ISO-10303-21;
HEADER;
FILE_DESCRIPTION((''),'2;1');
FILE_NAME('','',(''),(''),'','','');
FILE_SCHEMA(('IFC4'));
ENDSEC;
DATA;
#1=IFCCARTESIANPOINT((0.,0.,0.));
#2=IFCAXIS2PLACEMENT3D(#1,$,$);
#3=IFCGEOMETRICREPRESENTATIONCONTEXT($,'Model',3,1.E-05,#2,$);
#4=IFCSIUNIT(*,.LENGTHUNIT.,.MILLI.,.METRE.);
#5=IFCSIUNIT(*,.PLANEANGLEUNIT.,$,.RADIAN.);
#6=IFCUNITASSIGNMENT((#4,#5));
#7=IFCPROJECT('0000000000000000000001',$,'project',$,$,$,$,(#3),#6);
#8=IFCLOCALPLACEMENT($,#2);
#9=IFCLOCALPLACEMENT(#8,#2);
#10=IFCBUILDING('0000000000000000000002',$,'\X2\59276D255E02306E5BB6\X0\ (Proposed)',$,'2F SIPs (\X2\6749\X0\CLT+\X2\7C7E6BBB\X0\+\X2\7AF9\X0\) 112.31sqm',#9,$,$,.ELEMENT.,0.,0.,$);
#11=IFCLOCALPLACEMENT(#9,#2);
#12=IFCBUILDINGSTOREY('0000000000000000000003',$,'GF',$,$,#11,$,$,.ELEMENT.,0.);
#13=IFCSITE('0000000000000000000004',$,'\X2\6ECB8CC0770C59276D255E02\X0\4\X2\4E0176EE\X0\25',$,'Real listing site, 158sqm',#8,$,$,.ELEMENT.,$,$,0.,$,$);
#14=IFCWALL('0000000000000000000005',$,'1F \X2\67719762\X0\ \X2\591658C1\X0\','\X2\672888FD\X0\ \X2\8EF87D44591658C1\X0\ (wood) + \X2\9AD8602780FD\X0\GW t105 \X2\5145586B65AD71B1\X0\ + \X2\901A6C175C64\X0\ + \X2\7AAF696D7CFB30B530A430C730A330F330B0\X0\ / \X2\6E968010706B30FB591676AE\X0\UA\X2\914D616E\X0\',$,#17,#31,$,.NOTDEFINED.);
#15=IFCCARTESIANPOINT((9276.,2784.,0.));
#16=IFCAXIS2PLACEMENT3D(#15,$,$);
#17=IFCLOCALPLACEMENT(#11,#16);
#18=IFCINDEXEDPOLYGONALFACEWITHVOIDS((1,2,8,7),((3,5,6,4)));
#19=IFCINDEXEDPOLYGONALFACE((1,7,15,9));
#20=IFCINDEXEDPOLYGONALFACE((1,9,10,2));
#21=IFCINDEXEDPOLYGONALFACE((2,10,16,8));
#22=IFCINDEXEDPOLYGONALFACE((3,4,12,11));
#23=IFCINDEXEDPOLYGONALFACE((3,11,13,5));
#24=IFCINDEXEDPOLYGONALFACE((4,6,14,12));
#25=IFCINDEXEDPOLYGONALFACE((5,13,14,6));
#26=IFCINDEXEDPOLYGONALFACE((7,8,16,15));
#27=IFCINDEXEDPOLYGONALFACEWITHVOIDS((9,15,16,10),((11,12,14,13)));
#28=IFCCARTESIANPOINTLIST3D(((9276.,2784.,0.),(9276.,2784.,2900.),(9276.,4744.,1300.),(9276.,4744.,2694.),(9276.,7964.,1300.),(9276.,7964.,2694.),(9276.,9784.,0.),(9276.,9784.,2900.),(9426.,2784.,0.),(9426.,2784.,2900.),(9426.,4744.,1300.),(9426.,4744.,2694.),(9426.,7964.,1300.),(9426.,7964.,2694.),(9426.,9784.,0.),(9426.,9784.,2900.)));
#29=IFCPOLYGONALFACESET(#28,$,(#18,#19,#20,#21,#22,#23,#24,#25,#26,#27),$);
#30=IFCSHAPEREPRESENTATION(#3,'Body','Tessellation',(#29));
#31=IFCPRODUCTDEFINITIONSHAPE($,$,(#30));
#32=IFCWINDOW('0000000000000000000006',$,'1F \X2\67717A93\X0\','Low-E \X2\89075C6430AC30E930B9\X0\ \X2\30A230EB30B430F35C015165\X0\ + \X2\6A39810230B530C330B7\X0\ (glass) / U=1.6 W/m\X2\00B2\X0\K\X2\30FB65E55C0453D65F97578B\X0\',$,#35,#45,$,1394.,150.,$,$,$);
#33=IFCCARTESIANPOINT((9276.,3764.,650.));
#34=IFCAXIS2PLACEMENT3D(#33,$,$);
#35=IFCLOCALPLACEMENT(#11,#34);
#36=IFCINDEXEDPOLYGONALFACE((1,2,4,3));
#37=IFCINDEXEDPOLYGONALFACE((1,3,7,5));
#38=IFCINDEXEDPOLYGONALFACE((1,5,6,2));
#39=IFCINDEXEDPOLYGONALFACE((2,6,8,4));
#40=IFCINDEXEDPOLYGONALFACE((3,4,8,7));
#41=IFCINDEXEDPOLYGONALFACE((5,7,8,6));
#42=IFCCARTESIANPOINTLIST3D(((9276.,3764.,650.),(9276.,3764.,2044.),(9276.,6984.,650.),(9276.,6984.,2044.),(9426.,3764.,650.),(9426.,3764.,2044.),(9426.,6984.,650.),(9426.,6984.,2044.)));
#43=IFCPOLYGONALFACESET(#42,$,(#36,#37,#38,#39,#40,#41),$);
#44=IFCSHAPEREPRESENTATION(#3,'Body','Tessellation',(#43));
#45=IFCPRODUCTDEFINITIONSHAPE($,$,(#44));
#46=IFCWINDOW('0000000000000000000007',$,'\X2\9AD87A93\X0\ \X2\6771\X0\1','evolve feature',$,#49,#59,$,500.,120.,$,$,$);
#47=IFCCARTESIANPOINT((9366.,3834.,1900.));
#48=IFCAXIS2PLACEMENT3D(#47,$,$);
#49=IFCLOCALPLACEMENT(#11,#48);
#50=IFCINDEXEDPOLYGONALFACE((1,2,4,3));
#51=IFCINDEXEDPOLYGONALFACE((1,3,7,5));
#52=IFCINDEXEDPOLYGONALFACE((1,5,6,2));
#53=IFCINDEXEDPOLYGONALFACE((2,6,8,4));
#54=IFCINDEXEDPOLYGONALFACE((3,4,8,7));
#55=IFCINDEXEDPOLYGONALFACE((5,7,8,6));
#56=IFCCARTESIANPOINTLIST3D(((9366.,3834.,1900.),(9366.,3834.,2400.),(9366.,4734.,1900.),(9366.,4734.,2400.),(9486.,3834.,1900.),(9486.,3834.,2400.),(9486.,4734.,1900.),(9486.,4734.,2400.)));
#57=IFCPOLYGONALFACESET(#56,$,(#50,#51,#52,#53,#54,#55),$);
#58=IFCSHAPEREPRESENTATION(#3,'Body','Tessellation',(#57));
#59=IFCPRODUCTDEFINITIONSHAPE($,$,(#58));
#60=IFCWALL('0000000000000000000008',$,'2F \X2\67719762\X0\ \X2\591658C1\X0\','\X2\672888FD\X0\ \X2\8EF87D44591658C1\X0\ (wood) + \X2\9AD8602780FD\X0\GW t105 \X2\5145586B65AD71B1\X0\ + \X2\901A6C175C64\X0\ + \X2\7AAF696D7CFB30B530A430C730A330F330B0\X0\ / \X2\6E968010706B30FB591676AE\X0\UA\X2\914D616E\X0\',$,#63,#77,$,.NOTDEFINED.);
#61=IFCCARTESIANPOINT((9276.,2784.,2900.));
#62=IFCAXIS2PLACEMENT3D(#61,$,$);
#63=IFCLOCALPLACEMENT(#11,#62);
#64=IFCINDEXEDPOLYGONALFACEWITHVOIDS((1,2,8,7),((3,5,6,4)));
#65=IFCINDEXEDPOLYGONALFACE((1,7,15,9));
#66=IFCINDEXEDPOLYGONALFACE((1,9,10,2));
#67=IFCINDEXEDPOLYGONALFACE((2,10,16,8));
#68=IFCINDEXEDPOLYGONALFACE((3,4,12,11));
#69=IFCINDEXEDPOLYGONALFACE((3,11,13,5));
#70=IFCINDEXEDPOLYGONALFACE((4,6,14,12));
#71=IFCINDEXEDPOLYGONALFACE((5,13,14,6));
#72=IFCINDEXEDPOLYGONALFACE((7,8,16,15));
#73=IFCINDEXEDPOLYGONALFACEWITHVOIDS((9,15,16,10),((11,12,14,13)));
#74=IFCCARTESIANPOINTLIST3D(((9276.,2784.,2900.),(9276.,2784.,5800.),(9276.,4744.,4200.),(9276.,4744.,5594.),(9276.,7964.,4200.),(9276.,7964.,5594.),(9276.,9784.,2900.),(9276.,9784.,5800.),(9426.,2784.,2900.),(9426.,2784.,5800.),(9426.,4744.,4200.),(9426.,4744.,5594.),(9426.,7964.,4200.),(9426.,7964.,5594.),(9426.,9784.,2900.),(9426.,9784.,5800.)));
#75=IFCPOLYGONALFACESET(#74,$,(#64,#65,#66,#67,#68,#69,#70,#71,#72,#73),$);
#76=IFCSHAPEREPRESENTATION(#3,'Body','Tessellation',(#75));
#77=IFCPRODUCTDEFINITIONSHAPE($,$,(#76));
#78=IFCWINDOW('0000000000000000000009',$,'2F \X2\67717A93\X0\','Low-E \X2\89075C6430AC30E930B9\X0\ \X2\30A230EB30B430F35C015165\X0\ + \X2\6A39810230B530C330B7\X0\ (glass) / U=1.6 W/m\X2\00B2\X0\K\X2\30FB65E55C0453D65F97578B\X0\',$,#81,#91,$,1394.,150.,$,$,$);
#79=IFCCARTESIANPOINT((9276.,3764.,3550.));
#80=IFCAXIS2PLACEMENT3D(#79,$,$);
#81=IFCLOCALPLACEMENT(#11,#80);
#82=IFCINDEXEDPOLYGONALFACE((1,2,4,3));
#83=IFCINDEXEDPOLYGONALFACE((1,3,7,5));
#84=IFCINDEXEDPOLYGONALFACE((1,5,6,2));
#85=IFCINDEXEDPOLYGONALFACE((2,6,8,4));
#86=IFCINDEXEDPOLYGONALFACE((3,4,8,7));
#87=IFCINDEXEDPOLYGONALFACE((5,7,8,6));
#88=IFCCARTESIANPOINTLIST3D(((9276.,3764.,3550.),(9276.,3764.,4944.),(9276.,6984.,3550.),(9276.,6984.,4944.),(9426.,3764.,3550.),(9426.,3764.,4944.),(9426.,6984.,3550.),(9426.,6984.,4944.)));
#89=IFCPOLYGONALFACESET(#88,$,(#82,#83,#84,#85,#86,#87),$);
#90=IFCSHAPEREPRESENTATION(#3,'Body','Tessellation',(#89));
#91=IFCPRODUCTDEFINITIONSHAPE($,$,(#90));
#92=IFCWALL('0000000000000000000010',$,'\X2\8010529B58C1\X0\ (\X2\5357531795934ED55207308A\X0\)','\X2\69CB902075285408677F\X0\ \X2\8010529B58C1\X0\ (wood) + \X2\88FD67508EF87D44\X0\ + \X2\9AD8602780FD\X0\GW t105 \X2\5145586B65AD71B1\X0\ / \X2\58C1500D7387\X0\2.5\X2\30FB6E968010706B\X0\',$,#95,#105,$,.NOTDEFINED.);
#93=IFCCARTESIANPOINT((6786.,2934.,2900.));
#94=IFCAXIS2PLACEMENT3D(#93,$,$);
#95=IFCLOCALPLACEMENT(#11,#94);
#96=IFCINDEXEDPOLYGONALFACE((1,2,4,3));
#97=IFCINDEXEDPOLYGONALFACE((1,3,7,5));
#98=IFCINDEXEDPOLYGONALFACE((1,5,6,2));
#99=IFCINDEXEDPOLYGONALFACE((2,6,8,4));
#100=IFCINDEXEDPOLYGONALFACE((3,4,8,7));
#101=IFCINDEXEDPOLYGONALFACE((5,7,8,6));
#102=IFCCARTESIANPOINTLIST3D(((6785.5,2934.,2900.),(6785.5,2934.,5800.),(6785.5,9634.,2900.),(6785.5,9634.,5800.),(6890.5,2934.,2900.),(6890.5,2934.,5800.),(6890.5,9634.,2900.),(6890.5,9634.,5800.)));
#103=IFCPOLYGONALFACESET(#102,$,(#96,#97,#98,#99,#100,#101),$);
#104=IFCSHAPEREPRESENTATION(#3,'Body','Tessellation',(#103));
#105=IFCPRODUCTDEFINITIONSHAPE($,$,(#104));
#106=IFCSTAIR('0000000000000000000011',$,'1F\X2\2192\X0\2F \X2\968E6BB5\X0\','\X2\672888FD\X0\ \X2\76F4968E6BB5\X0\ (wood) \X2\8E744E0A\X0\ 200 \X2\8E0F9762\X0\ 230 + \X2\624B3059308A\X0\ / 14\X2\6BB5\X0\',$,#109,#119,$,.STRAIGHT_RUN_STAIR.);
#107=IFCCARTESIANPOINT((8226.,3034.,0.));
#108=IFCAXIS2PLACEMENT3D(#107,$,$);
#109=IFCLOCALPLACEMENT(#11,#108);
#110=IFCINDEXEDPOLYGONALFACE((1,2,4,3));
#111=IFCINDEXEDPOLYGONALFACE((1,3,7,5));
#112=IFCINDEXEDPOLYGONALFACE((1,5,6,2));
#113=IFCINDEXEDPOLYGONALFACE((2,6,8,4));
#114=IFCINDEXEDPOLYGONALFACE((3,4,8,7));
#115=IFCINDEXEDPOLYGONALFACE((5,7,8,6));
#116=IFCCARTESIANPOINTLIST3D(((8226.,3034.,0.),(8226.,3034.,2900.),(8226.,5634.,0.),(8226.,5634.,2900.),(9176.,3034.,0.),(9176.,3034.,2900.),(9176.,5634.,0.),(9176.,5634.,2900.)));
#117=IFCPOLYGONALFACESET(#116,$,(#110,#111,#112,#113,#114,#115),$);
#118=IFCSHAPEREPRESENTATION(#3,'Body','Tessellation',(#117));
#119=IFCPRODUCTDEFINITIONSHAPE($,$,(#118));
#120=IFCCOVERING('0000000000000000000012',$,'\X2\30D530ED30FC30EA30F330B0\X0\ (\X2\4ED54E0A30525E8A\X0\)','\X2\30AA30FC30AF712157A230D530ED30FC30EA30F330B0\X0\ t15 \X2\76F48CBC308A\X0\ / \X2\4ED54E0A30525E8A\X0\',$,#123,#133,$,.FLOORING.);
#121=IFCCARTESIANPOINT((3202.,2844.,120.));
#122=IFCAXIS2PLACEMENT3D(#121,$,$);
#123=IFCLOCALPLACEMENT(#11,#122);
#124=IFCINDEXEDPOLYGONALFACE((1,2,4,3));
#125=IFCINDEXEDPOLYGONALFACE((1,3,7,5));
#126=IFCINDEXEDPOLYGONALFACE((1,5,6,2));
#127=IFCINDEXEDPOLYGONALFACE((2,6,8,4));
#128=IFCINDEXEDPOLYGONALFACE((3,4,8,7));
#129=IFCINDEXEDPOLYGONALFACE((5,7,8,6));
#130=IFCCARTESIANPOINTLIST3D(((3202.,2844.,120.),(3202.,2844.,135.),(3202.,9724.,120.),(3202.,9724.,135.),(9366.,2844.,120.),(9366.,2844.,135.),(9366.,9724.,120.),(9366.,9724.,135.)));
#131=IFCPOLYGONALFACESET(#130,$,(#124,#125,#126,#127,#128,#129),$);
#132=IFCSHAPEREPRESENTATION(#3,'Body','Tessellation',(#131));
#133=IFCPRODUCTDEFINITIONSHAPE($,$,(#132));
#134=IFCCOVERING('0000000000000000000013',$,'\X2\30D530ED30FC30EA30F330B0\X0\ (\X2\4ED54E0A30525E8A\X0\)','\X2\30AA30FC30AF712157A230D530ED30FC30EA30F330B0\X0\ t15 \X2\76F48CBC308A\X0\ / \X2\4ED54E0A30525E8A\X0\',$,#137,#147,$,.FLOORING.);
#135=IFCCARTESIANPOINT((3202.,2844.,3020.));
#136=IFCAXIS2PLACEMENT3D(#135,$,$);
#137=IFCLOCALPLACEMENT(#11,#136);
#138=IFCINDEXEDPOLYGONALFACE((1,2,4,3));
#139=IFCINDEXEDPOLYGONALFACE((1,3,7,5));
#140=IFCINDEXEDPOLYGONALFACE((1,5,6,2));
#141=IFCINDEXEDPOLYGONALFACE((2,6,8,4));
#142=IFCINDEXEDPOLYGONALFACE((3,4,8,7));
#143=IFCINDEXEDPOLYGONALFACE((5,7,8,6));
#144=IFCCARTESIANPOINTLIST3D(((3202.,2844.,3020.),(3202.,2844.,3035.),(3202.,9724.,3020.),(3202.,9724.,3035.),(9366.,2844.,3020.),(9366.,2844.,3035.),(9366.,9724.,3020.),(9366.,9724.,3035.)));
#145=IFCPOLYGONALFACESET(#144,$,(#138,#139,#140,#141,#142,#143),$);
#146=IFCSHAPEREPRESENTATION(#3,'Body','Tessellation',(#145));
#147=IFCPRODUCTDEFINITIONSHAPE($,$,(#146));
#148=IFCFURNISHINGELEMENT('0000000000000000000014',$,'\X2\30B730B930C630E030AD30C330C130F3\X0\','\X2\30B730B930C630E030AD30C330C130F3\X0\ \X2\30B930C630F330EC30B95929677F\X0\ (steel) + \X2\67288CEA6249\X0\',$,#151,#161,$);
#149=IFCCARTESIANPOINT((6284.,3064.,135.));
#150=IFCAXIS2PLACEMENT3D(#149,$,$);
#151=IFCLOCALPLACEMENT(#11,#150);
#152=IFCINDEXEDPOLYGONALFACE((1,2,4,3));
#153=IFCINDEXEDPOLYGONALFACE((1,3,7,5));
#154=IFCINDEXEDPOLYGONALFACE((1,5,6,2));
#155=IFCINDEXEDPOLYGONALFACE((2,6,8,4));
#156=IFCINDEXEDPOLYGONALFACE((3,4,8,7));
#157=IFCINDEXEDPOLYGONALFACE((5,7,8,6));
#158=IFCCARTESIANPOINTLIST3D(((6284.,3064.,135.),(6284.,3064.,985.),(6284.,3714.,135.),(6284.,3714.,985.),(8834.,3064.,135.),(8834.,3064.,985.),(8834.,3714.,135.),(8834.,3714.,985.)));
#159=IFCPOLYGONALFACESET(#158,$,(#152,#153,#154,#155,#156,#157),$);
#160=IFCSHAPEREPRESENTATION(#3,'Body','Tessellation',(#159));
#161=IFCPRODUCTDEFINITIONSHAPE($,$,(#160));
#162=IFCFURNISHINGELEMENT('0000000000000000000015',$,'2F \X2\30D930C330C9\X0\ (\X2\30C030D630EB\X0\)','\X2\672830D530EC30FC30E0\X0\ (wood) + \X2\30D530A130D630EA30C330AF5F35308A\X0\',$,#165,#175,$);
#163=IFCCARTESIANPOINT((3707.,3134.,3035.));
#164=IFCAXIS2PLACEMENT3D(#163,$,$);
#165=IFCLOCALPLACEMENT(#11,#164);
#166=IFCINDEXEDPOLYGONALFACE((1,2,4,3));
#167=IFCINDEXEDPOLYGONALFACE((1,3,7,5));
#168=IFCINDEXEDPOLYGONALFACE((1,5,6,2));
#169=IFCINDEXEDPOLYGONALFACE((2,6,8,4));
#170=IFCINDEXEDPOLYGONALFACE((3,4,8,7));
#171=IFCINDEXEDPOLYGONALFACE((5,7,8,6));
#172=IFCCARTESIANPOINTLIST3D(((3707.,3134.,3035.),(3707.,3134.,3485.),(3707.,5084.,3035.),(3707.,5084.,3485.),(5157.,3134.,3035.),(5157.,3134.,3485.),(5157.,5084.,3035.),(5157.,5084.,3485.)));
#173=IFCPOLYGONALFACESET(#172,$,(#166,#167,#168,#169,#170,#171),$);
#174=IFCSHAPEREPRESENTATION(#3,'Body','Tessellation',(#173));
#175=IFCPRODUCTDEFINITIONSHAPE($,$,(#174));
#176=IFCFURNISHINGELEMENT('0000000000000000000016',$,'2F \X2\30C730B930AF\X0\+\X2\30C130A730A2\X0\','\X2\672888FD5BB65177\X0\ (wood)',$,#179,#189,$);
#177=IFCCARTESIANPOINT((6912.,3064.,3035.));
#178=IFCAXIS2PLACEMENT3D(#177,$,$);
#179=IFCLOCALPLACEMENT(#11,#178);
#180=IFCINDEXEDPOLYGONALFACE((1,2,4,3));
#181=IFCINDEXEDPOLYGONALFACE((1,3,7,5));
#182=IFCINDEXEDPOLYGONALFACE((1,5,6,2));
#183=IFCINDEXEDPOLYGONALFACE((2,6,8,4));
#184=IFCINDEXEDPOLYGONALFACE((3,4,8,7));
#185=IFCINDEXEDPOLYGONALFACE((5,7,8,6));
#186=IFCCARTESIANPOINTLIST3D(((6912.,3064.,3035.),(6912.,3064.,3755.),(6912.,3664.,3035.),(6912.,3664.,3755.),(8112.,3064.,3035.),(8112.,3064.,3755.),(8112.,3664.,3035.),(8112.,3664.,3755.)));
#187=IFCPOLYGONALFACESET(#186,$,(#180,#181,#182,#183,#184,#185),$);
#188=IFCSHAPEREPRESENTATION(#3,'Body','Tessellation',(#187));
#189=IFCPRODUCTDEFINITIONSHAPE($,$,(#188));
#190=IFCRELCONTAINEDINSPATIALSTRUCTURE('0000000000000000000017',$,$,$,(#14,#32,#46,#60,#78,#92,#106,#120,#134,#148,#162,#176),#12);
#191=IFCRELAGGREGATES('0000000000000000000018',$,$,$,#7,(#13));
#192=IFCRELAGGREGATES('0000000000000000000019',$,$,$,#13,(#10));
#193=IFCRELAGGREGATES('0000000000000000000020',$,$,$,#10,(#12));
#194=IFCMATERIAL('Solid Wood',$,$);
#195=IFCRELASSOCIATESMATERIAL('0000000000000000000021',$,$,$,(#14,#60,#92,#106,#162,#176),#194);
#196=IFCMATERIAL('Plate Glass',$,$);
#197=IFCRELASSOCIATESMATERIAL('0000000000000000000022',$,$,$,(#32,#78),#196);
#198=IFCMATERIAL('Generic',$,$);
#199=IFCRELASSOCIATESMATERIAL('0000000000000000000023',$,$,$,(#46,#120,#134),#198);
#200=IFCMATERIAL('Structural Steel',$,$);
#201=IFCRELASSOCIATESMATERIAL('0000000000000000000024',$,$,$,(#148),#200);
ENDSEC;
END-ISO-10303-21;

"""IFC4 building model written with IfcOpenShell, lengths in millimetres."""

from ifc_helpers import new_model, si_unit, frame, frame_2d, origin, place, context, project, spatial, rectangle, extrude, material, element, fill, save


model = new_model("IFC4")

# Units and contexts
model_context = context("Model", 3, precision=1e-05, world=origin())
ifc_project = project(units=[si_unit("LENGTHUNIT", "METRE", prefix="MILLI"), si_unit("PLANEANGLEUNIT", "RADIAN")], contexts=[model_context])

# Site, building, storey
site_placement = place(None, origin())
site = spatial("IfcSite", under=ifc_project, at=site_placement, Name="滋賀県大津市4丁目25", ObjectType="Real listing site, 158sqm", CompositionType="ELEMENT", RefElevation=0.0)
building_placement = place(site_placement, origin())
building = spatial("IfcBuilding", under=site, at=building_placement, Name="大津市の家 (Proposed)", ObjectType="2F SIPs (杉CLT+籾殻+竹) 112.31sqm", CompositionType="ELEMENT", ElevationOfRefHeight=0.0, ElevationOfTerrain=0.0)
storey_placement = place(building_placement, origin())
storey = spatial("IfcBuildingStorey", under=building, at=storey_placement, Name="GF", CompositionType="ELEMENT", Elevation=0.0)

# Shared definitions
ifc_material_1 = material(Name="Solid Wood")

# Wall, openings, windows
wall_1_placement = place(storey_placement, frame((9276.0, 2784.0, 0.0)))
wall_1 = element("IfcWall", 1, at=wall_1_placement, inside=storey, material=ifc_material_1, Name="1F 東面 外壁", Description="木製 軸組外壁 (wood) + 高性能GW t105 充填断熱 + 通気層 + 窯業系サイディング / 準耐火・外皮UA配慮", PredefinedType="NOTDEFINED", context=model_context, shape_type="SweptSolid", body=[
    extrude(rectangle(XDim=150.0, YDim=7000.0, at=frame_2d((75.0, 3500.0))), frame((9276.0, 2784.0, 0.0)), (0.0, 0.0, 1.0), 2900.0),
])
opening_1_placement = place(storey_placement, frame((9276.0, 3764.0, 650.0)))
opening_1 = element("IfcOpeningElement", 2, at=opening_1_placement, cuts=wall_1, PredefinedType="NOTDEFINED", context=model_context, shape_type="SweptSolid", body=[
    extrude(rectangle(XDim=150.0, YDim=3220.0, at=frame_2d((75.0, 1610.0))), frame((9276.0, 3764.0, 650.0)), (0.0, 0.0, 1.0), 1394.0),
])
opening_2_placement = place(storey_placement, frame((9366.0, 3834.0, 1900.0)))
opening_2 = element("IfcOpeningElement", 3, at=opening_2_placement, cuts=wall_1, PredefinedType="NOTDEFINED", context=model_context, shape_type="SweptSolid", body=[
    extrude(rectangle(XDim=120.0, YDim=900.0, at=frame_2d((60.0, 450.0))), frame((9366.0, 3834.0, 1900.0)), (0.0, 0.0, 1.0), 500.0),
])
ifc_material_2 = material(Name="Plate Glass")
window_1_placement = place(storey_placement, frame((9276.0, 3764.0, 650.0)))
window_1 = element("IfcWindow", 4, at=window_1_placement, inside=storey, material=ifc_material_2, Name="1F 東窓", Description="Low-E 複層ガラス アルゴン封入 + 樹脂サッシ (glass) / U=1.6 W/m²K・日射取得型", OverallHeight=1394.0, OverallWidth=150.0, context=model_context, shape_type="SweptSolid", body=[
    extrude(rectangle(XDim=150.0, YDim=3220.0, at=frame_2d((75.0, 1610.0))), frame((9276.0, 3764.0, 650.0)), (0.0, 0.0, 1.0), 1394.0),
])
fill(opening_1, window_1)
ifc_material_3 = material(Name="Generic")
window_2_placement = place(storey_placement, frame((9366.0, 3834.0, 1900.0)))
window_2 = element("IfcWindow", 5, at=window_2_placement, inside=storey, material=ifc_material_3, Name="高窓 東1", Description="evolve feature", OverallHeight=500.0, OverallWidth=120.0, context=model_context, shape_type="SweptSolid", body=[
    extrude(rectangle(XDim=120.0, YDim=900.0, at=frame_2d((60.0, 450.0))), frame((9366.0, 3834.0, 1900.0)), (0.0, 0.0, 1.0), 500.0),
])
fill(opening_2, window_2)

# Wall, opening, window
wall_2_placement = place(storey_placement, frame((9276.0, 2784.0, 2900.0)))
wall_2 = element("IfcWall", 6, at=wall_2_placement, inside=storey, material=ifc_material_1, Name="2F 東面 外壁", Description="木製 軸組外壁 (wood) + 高性能GW t105 充填断熱 + 通気層 + 窯業系サイディング / 準耐火・外皮UA配慮", PredefinedType="NOTDEFINED", context=model_context, shape_type="SweptSolid", body=[
    extrude(rectangle(XDim=150.0, YDim=7000.0, at=frame_2d((75.0, 3500.0))), frame((9276.0, 2784.0, 2900.0)), (0.0, 0.0, 1.0), 2900.0),
])
opening_3_placement = place(storey_placement, frame((9276.0, 3764.0, 3550.0)))
opening_3 = element("IfcOpeningElement", 7, at=opening_3_placement, cuts=wall_2, PredefinedType="NOTDEFINED", context=model_context, shape_type="SweptSolid", body=[
    extrude(rectangle(XDim=150.0, YDim=3220.0, at=frame_2d((75.0, 1610.0))), frame((9276.0, 3764.0, 3550.0)), (0.0, 0.0, 1.0), 1394.0),
])
window_3_placement = place(storey_placement, frame((9276.0, 3764.0, 3550.0)))
window_3 = element("IfcWindow", 8, at=window_3_placement, inside=storey, material=ifc_material_2, Name="2F 東窓", Description="Low-E 複層ガラス アルゴン封入 + 樹脂サッシ (glass) / U=1.6 W/m²K・日射取得型", OverallHeight=1394.0, OverallWidth=150.0, context=model_context, shape_type="SweptSolid", body=[
    extrude(rectangle(XDim=150.0, YDim=3220.0, at=frame_2d((75.0, 1610.0))), frame((9276.0, 3764.0, 3550.0)), (0.0, 0.0, 1.0), 1394.0),
])
fill(opening_3, window_3)

# Wall
wall_3_placement = place(storey_placement, frame((6786.0, 2934.0, 2900.0)))
element("IfcWall", 9, at=wall_3_placement, inside=storey, material=ifc_material_1, Name="耐力壁 (南北間仕切り)", Description="構造用合板 耐力壁 (wood) + 製材軸組 + 高性能GW t105 充填断熱 / 壁倍率2.5・準耐火", PredefinedType="NOTDEFINED", context=model_context, shape_type="SweptSolid", body=[
    extrude(rectangle(XDim=105.0, YDim=6700.0, at=frame_2d((52.0, 3350.0))), frame((6786.0, 2934.0, 2900.0)), (0.0, 0.0, 1.0), 2900.0),
])

# Stair
stair_placement = place(storey_placement, frame((8226.0, 3034.0, 0.0)))
element("IfcStair", 10, at=stair_placement, inside=storey, material=ifc_material_1, Name="1F→2F 階段", Description="木製 直階段 (wood) 蹴上 200 踏面 230 + 手すり / 14段", PredefinedType="STRAIGHT_RUN_STAIR", context=model_context, shape_type="SweptSolid", body=[
    extrude(rectangle(XDim=950.0, YDim=2600.0, at=frame_2d((475.0, 1300.0))), frame((8226.0, 3034.0, 0.0)), (0.0, 0.0, 1.0), 2900.0),
])

# Coverings
covering_1_placement = place(storey_placement, frame((3202.0, 2844.0, 120.0)))
element("IfcCovering", 11, at=covering_1_placement, inside=storey, material=ifc_material_3, Name="フローリング (仕上げ床)", Description="オーク無垢フローリング t15 直貼り / 仕上げ床", PredefinedType="FLOORING", context=model_context, shape_type="SweptSolid", body=[
    extrude(rectangle(XDim=6164.0, YDim=6880.0, at=frame_2d((3082.0, 3440.0))), frame((3202.0, 2844.0, 120.0)), (0.0, 0.0, 1.0), 15.0),
])
covering_2_placement = place(storey_placement, frame((3202.0, 2844.0, 3020.0)))
element("IfcCovering", 12, at=covering_2_placement, inside=storey, material=ifc_material_3, Name="フローリング (仕上げ床)", Description="オーク無垢フローリング t15 直貼り / 仕上げ床", PredefinedType="FLOORING", context=model_context, shape_type="SweptSolid", body=[
    extrude(rectangle(XDim=6164.0, YDim=6880.0, at=frame_2d((3082.0, 3440.0))), frame((3202.0, 2844.0, 3020.0)), (0.0, 0.0, 1.0), 15.0),
])

# Furnishing elements
ifc_material_4 = material(Name="Structural Steel")
furnishing_1_placement = place(storey_placement, frame((6284.0, 3064.0, 135.0)))
element("IfcFurnishingElement", 13, at=furnishing_1_placement, inside=storey, material=ifc_material_4, Name="システムキッチン", Description="システムキッチン ステンレス天板 (steel) + 木質扉", context=model_context, shape_type="SweptSolid", body=[
    extrude(rectangle(XDim=2550.0, YDim=650.0, at=frame_2d((1275.0, 325.0))), frame((6284.0, 3064.0, 135.0)), (0.0, 0.0, 1.0), 850.0),
])
furnishing_2_placement = place(storey_placement, frame((3707.0, 3134.0, 3035.0)))
element("IfcFurnishingElement", 14, at=furnishing_2_placement, inside=storey, material=ifc_material_1, Name="2F ベッド (ダブル)", Description="木フレーム (wood) + ファブリック張り", context=model_context, shape_type="SweptSolid", body=[
    extrude(rectangle(XDim=1450.0, YDim=1950.0, at=frame_2d((725.0, 975.0))), frame((3707.0, 3134.0, 3035.0)), (0.0, 0.0, 1.0), 450.0),
])
furnishing_3_placement = place(storey_placement, frame((6912.0, 3064.0, 3035.0)))
element("IfcFurnishingElement", 15, at=furnishing_3_placement, inside=storey, material=ifc_material_1, Name="2F デスク+チェア", Description="木製家具 (wood)", context=model_context, shape_type="SweptSolid", body=[
    extrude(rectangle(XDim=1200.0, YDim=600.0, at=frame_2d((600.0, 300.0))), frame((6912.0, 3064.0, 3035.0)), (0.0, 0.0, 1.0), 720.0),
])

save(model, "model.ifc")
